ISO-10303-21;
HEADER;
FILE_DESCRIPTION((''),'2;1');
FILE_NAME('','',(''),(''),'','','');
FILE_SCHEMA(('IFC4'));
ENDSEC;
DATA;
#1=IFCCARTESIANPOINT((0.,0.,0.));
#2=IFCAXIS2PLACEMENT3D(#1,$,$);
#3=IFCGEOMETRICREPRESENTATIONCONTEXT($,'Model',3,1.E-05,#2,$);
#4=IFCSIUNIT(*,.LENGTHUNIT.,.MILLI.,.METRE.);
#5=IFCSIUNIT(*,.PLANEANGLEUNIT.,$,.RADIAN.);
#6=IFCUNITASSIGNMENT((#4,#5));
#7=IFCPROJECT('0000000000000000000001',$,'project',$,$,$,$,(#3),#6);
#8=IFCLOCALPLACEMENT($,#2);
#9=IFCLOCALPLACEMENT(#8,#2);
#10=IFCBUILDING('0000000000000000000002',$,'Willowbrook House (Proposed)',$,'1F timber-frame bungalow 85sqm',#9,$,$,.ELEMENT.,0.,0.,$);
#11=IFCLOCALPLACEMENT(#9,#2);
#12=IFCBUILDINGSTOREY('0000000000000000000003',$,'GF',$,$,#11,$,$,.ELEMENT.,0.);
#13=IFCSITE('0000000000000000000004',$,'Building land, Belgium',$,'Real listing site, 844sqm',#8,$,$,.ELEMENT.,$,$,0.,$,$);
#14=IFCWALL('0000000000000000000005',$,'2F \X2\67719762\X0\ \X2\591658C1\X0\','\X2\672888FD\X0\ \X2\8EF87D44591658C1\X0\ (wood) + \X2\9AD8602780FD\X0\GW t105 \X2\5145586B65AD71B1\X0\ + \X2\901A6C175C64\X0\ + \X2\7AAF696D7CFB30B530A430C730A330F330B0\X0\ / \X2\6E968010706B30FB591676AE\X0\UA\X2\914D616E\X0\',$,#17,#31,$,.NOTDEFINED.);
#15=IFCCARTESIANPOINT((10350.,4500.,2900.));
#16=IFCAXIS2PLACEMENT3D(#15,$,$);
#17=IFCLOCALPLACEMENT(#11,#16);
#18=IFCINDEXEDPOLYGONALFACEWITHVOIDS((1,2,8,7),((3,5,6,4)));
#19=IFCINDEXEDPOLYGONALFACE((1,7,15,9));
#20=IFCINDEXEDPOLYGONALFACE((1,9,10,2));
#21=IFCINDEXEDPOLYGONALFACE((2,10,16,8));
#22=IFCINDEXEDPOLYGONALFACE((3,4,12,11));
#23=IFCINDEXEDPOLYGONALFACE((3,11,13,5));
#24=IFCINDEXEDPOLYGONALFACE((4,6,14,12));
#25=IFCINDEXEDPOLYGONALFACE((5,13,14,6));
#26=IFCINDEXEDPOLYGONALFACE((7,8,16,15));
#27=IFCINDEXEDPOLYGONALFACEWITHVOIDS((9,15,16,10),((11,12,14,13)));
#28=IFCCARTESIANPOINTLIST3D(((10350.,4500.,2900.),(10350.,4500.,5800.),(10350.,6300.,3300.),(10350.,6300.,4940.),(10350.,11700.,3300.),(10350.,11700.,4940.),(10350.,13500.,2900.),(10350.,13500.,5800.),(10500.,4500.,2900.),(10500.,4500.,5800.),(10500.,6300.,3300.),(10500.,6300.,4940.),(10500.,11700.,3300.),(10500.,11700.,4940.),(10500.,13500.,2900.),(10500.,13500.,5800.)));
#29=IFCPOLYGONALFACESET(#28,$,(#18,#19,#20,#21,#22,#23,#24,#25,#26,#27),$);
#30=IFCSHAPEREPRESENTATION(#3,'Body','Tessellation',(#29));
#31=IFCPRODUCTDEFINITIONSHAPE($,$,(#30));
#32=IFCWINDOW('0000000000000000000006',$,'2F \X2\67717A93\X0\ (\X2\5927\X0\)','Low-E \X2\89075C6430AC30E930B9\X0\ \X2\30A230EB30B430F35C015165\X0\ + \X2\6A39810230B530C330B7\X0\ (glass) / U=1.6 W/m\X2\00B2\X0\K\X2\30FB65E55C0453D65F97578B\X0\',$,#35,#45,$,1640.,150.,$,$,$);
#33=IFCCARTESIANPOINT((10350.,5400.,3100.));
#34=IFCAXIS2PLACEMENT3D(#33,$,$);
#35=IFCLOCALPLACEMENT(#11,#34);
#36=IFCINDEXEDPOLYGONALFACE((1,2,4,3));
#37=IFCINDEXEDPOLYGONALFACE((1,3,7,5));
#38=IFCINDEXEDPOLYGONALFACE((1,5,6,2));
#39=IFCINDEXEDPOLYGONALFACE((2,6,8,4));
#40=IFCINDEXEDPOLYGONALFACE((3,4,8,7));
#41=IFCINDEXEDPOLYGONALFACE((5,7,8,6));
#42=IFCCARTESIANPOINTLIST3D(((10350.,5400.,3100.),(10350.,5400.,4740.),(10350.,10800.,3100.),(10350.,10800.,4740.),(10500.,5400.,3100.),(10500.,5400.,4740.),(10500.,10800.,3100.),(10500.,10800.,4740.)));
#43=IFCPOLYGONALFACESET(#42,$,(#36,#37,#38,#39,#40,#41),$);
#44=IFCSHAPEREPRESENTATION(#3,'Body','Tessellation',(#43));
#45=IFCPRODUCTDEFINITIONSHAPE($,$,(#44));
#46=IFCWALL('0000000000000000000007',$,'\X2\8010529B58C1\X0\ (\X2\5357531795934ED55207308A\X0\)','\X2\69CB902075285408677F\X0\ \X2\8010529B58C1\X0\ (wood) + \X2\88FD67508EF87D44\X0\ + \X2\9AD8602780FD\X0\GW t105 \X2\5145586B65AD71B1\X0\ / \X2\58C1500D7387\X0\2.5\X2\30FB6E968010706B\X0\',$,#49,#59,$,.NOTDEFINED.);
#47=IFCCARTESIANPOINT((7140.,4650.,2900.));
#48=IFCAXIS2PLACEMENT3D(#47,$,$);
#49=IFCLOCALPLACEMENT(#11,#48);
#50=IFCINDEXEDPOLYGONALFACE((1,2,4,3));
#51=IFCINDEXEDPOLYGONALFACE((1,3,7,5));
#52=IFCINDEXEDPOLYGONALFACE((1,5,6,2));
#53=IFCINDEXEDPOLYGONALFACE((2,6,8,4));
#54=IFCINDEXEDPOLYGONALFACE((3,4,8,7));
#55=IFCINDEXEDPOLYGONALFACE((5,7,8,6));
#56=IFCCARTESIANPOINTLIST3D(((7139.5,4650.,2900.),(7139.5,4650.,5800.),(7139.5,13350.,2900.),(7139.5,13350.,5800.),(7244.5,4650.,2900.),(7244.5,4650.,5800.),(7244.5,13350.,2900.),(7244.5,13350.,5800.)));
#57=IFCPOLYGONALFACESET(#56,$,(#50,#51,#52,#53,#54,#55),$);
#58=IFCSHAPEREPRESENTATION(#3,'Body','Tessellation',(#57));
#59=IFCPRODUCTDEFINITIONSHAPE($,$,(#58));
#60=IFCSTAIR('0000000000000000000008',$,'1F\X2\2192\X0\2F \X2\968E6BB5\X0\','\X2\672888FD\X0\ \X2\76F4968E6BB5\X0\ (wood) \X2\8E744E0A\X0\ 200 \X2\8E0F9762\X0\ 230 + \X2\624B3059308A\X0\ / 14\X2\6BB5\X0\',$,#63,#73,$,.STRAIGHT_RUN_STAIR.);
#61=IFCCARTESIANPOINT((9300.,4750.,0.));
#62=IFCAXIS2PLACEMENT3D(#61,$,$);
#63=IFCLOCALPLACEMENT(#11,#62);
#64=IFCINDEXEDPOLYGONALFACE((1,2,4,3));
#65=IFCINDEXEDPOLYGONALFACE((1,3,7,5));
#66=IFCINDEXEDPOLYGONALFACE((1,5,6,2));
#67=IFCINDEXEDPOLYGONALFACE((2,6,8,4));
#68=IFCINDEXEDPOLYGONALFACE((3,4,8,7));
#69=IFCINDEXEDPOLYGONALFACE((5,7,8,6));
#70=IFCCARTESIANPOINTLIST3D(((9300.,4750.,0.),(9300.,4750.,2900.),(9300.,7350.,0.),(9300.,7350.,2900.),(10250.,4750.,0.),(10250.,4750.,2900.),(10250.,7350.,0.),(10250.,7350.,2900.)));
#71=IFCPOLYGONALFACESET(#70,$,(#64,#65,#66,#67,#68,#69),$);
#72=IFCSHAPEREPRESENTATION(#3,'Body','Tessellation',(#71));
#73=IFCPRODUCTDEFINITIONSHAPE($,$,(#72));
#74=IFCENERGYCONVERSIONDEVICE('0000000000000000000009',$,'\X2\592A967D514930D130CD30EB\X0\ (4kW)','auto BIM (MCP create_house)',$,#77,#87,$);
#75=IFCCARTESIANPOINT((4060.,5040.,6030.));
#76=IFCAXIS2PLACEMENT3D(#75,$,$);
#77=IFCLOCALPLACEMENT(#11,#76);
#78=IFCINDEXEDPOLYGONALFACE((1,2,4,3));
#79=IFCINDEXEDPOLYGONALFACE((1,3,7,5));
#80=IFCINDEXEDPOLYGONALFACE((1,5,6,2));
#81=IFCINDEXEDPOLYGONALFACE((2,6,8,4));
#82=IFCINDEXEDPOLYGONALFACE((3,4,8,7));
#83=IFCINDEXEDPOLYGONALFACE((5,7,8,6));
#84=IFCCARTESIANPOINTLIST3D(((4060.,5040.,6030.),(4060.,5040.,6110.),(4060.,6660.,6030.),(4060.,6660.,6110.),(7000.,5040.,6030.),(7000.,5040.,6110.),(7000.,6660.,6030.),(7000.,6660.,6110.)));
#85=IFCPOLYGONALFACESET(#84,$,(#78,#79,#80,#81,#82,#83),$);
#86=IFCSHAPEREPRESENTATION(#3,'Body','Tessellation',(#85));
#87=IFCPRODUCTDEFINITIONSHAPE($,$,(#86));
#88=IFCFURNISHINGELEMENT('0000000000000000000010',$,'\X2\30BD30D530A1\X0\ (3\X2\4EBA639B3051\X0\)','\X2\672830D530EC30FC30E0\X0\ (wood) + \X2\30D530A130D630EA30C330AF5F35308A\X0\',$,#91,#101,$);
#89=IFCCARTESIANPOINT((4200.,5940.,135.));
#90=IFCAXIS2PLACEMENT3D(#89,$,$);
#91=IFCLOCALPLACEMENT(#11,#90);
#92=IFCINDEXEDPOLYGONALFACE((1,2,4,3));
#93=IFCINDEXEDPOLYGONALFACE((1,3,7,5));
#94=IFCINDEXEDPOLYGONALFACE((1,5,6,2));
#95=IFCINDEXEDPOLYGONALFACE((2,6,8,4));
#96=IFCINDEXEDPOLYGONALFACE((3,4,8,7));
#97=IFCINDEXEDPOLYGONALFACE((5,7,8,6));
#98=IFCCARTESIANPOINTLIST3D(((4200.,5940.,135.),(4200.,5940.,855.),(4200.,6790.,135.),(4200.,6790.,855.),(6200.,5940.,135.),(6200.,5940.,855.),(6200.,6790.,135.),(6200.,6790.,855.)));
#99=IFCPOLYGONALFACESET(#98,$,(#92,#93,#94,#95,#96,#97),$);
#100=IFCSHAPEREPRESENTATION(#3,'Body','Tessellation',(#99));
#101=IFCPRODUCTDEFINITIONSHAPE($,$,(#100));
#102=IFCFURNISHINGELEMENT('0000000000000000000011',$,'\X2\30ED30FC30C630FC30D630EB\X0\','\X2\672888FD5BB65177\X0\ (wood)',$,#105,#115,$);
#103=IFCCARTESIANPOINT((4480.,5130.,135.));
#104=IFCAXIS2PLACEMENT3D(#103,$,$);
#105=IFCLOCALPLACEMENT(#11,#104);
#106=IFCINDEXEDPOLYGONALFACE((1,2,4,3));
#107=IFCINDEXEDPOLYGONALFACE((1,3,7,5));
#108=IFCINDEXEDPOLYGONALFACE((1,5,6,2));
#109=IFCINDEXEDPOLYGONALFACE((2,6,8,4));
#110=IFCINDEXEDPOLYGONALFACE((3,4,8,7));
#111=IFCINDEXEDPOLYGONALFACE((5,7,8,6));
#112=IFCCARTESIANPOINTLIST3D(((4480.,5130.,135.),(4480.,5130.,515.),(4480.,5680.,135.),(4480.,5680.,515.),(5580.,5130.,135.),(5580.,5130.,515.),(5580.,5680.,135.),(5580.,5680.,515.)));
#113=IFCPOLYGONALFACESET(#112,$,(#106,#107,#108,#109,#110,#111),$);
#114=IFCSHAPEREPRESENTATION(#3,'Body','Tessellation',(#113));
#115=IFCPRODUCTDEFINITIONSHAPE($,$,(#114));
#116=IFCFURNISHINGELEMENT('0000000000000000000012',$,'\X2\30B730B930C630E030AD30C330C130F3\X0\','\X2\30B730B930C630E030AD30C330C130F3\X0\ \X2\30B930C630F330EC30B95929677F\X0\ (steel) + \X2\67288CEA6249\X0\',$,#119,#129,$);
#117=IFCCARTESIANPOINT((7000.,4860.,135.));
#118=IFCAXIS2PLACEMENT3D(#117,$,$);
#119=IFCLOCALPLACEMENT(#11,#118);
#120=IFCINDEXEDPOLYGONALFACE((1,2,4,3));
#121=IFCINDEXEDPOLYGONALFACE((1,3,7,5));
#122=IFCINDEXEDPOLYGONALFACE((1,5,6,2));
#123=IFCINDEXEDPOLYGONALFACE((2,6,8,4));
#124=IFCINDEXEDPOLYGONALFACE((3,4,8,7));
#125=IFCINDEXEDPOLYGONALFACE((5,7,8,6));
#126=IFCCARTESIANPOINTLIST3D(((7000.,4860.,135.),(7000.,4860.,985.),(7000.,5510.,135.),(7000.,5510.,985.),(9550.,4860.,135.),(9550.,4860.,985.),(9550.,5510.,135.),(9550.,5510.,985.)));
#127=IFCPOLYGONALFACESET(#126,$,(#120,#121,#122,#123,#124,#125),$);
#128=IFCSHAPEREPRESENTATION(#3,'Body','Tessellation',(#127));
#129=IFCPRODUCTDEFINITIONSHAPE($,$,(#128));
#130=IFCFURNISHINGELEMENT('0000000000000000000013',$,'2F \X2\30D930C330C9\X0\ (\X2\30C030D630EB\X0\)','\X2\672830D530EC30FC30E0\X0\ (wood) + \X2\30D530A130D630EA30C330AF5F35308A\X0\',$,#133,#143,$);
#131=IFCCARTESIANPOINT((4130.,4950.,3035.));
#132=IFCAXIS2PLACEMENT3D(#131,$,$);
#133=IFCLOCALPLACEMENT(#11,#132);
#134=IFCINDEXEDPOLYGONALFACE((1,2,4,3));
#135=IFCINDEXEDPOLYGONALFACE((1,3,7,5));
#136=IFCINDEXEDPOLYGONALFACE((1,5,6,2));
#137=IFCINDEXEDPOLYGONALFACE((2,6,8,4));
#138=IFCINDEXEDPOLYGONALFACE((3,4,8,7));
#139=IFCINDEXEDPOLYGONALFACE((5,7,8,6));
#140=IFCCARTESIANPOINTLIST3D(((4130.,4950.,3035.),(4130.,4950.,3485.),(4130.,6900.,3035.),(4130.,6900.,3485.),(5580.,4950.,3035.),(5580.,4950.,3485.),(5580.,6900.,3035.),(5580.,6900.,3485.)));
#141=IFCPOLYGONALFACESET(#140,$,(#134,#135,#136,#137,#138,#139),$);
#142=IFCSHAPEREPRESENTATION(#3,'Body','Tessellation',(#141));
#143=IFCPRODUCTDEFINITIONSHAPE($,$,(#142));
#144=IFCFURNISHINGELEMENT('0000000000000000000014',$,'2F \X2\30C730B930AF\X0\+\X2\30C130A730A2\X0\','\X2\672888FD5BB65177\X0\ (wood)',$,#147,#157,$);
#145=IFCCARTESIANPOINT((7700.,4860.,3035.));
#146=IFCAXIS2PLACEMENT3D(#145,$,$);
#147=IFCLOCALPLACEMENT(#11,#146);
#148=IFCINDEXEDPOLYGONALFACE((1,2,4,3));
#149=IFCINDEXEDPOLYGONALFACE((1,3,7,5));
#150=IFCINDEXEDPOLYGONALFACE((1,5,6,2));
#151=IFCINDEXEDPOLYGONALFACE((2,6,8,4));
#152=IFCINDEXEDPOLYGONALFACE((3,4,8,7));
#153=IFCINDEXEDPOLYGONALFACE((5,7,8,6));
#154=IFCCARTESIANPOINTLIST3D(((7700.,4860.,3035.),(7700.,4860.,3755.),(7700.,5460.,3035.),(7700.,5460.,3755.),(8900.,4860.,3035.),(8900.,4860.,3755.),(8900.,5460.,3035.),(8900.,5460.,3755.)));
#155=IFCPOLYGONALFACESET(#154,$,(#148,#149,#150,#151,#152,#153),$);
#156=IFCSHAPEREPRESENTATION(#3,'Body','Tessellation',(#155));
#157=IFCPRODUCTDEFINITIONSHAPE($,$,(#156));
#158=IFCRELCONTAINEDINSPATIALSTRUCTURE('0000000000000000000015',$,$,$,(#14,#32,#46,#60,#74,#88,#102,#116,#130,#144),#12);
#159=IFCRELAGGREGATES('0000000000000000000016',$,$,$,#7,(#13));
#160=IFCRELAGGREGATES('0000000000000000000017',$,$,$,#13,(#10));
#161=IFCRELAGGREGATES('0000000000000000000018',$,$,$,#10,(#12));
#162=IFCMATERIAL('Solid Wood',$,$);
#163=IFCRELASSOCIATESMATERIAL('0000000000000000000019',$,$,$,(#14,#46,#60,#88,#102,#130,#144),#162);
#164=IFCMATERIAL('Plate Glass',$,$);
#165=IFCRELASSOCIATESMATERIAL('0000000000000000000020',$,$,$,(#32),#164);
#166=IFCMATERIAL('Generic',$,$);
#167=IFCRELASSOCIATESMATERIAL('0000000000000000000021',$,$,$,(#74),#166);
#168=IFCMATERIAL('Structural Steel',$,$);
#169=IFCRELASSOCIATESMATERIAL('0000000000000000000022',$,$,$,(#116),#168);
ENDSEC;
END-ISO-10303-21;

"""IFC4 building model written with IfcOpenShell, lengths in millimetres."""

from ifc_helpers import new_model, si_unit, frame, frame_2d, origin, place, context, project, spatial, rectangle, extrude, material, element, fill, save


model = new_model("IFC4")

# Units and contexts
model_context = context("Model", 3, precision=1e-05, world=origin())
ifc_project = project(units=[si_unit("LENGTHUNIT", "METRE", prefix="MILLI"), si_unit("PLANEANGLEUNIT", "RADIAN")], contexts=[model_context])

# Site, building, storey
site_placement = place(None, origin())
site = spatial("IfcSite", under=ifc_project, at=site_placement, Name="Building land, Belgium", ObjectType="Real listing site, 844sqm", CompositionType="ELEMENT", RefElevation=0.0)
building_placement = place(site_placement, origin())
building = spatial("IfcBuilding", under=site, at=building_placement, Name="Willowbrook House (Proposed)", ObjectType="1F timber-frame bungalow 85sqm", CompositionType="ELEMENT", ElevationOfRefHeight=0.0, ElevationOfTerrain=0.0)
storey_placement = place(building_placement, origin())
storey = spatial("IfcBuildingStorey", under=building, at=storey_placement, Name="GF", CompositionType="ELEMENT", Elevation=0.0)

# Shared definitions
ifc_material_1 = material(Name="Solid Wood")
ifc_material_2 = material(Name="Plate Glass")

# Wall, opening, window
wall_1_placement = place(storey_placement, frame((10350.0, 4500.0, 2900.0)))
wall_1 = element("IfcWall", 1, at=wall_1_placement, inside=storey, material=ifc_material_1, Name="2F 東面 外壁", Description="木製 軸組外壁 (wood) + 高性能GW t105 充填断熱 + 通気層 + 窯業系サイディング / 準耐火・外皮UA配慮", PredefinedType="NOTDEFINED", context=model_context, shape_type="SweptSolid", body=[
    extrude(rectangle(XDim=150.0, YDim=9000.0, at=frame_2d((75.0, 4500.0))), frame((10350.0, 4500.0, 2900.0)), (0.0, 0.0, 1.0), 2900.0),
])
opening_1_placement = place(storey_placement, frame((10350.0, 5400.0, 3100.0)))
opening_1 = element("IfcOpeningElement", 2, at=opening_1_placement, cuts=wall_1, PredefinedType="NOTDEFINED", context=model_context, shape_type="SweptSolid", body=[
    extrude(rectangle(XDim=150.0, YDim=5400.0, at=frame_2d((75.0, 2700.0))), frame((10350.0, 5400.0, 3100.0)), (0.0, 0.0, 1.0), 1640.0),
])
window_1_placement = place(storey_placement, frame((10350.0, 5400.0, 3100.0)))
window_1 = element("IfcWindow", 3, at=window_1_placement, inside=storey, material=ifc_material_2, Name="2F 東窓 (大)", Description="Low-E 複層ガラス アルゴン封入 + 樹脂サッシ (glass) / U=1.6 W/m²K・日射取得型", OverallHeight=1640.0, OverallWidth=150.0, context=model_context, shape_type="SweptSolid", body=[
    extrude(rectangle(XDim=150.0, YDim=5400.0, at=frame_2d((75.0, 2700.0))), frame((10350.0, 5400.0, 3100.0)), (0.0, 0.0, 1.0), 1640.0),
])
fill(opening_1, window_1)

# Wall
wall_2_placement = place(storey_placement, frame((7140.0, 4650.0, 2900.0)))
element("IfcWall", 4, at=wall_2_placement, inside=storey, material=ifc_material_1, Name="耐力壁 (南北間仕切り)", Description="構造用合板 耐力壁 (wood) + 製材軸組 + 高性能GW t105 充填断熱 / 壁倍率2.5・準耐火", PredefinedType="NOTDEFINED", context=model_context, shape_type="SweptSolid", body=[
    extrude(rectangle(XDim=105.0, YDim=8700.0, at=frame_2d((52.0, 4350.0))), frame((7140.0, 4650.0, 2900.0)), (0.0, 0.0, 1.0), 2900.0),
])

# Stair
stair_placement = place(storey_placement, frame((9300.0, 4750.0, 0.0)))
element("IfcStair", 5, at=stair_placement, inside=storey, material=ifc_material_1, Name="1F→2F 階段", Description="木製 直階段 (wood) 蹴上 200 踏面 230 + 手すり / 14段", PredefinedType="STRAIGHT_RUN_STAIR", context=model_context, shape_type="SweptSolid", body=[
    extrude(rectangle(XDim=950.0, YDim=2600.0, at=frame_2d((475.0, 1300.0))), frame((9300.0, 4750.0, 0.0)), (0.0, 0.0, 1.0), 2900.0),
])

# Energy conversion device
ifc_material_3 = material(Name="Generic")
energy_conversion_device_placement = place(storey_placement, frame((4060.0, 5040.0, 6030.0)))
element("IfcEnergyConversionDevice", 6, at=energy_conversion_device_placement, inside=storey, material=ifc_material_3, Name="太陽光パネル (4kW)", Description="auto BIM (MCP create_house)", context=model_context, shape_type="SweptSolid", body=[
    extrude(rectangle(XDim=2940.0, YDim=1620.0, at=frame_2d((1470.0, 810.0))), frame((4060.0, 5040.0, 6030.0)), (0.0, 0.0, 1.0), 80.0),
])

# Furnishing elements
furnishing_1_placement = place(storey_placement, frame((4200.0, 5940.0, 135.0)))
element("IfcFurnishingElement", 7, at=furnishing_1_placement, inside=storey, material=ifc_material_1, Name="ソファ (3人掛け)", Description="木フレーム (wood) + ファブリック張り", context=model_context, shape_type="SweptSolid", body=[
    extrude(rectangle(XDim=2000.0, YDim=850.0, at=frame_2d((1000.0, 425.0))), frame((4200.0, 5940.0, 135.0)), (0.0, 0.0, 1.0), 720.0),
])
furnishing_2_placement = place(storey_placement, frame((4480.0, 5130.0, 135.0)))
element("IfcFurnishingElement", 8, at=furnishing_2_placement, inside=storey, material=ifc_material_1, Name="ローテーブル", Description="木製家具 (wood)", context=model_context, shape_type="SweptSolid", body=[
    extrude(rectangle(XDim=1100.0, YDim=550.0, at=frame_2d((550.0, 275.0))), frame((4480.0, 5130.0, 135.0)), (0.0, 0.0, 1.0), 380.0),
])
ifc_material_4 = material(Name="Structural Steel")
furnishing_3_placement = place(storey_placement, frame((7000.0, 4860.0, 135.0)))
element("IfcFurnishingElement", 9, at=furnishing_3_placement, inside=storey, material=ifc_material_4, Name="システムキッチン", Description="システムキッチン ステンレス天板 (steel) + 木質扉", context=model_context, shape_type="SweptSolid", body=[
    extrude(rectangle(XDim=2550.0, YDim=650.0, at=frame_2d((1275.0, 325.0))), frame((7000.0, 4860.0, 135.0)), (0.0, 0.0, 1.0), 850.0),
])
furnishing_4_placement = place(storey_placement, frame((4130.0, 4950.0, 3035.0)))
element("IfcFurnishingElement", 10, at=furnishing_4_placement, inside=storey, material=ifc_material_1, Name="2F ベッド (ダブル)", Description="木フレーム (wood) + ファブリック張り", context=model_context, shape_type="SweptSolid", body=[
    extrude(rectangle(XDim=1450.0, YDim=1950.0, at=frame_2d((725.0, 975.0))), frame((4130.0, 4950.0, 3035.0)), (0.0, 0.0, 1.0), 450.0),
])
furnishing_5_placement = place(storey_placement, frame((7700.0, 4860.0, 3035.0)))
element("IfcFurnishingElement", 11, at=furnishing_5_placement, inside=storey, material=ifc_material_1, Name="2F デスク+チェア", Description="木製家具 (wood)", context=model_context, shape_type="SweptSolid", body=[
    extrude(rectangle(XDim=1200.0, YDim=600.0, at=frame_2d((600.0, 300.0))), frame((7700.0, 4860.0, 3035.0)), (0.0, 0.0, 1.0), 720.0),
])

save(model, "model.ifc")
